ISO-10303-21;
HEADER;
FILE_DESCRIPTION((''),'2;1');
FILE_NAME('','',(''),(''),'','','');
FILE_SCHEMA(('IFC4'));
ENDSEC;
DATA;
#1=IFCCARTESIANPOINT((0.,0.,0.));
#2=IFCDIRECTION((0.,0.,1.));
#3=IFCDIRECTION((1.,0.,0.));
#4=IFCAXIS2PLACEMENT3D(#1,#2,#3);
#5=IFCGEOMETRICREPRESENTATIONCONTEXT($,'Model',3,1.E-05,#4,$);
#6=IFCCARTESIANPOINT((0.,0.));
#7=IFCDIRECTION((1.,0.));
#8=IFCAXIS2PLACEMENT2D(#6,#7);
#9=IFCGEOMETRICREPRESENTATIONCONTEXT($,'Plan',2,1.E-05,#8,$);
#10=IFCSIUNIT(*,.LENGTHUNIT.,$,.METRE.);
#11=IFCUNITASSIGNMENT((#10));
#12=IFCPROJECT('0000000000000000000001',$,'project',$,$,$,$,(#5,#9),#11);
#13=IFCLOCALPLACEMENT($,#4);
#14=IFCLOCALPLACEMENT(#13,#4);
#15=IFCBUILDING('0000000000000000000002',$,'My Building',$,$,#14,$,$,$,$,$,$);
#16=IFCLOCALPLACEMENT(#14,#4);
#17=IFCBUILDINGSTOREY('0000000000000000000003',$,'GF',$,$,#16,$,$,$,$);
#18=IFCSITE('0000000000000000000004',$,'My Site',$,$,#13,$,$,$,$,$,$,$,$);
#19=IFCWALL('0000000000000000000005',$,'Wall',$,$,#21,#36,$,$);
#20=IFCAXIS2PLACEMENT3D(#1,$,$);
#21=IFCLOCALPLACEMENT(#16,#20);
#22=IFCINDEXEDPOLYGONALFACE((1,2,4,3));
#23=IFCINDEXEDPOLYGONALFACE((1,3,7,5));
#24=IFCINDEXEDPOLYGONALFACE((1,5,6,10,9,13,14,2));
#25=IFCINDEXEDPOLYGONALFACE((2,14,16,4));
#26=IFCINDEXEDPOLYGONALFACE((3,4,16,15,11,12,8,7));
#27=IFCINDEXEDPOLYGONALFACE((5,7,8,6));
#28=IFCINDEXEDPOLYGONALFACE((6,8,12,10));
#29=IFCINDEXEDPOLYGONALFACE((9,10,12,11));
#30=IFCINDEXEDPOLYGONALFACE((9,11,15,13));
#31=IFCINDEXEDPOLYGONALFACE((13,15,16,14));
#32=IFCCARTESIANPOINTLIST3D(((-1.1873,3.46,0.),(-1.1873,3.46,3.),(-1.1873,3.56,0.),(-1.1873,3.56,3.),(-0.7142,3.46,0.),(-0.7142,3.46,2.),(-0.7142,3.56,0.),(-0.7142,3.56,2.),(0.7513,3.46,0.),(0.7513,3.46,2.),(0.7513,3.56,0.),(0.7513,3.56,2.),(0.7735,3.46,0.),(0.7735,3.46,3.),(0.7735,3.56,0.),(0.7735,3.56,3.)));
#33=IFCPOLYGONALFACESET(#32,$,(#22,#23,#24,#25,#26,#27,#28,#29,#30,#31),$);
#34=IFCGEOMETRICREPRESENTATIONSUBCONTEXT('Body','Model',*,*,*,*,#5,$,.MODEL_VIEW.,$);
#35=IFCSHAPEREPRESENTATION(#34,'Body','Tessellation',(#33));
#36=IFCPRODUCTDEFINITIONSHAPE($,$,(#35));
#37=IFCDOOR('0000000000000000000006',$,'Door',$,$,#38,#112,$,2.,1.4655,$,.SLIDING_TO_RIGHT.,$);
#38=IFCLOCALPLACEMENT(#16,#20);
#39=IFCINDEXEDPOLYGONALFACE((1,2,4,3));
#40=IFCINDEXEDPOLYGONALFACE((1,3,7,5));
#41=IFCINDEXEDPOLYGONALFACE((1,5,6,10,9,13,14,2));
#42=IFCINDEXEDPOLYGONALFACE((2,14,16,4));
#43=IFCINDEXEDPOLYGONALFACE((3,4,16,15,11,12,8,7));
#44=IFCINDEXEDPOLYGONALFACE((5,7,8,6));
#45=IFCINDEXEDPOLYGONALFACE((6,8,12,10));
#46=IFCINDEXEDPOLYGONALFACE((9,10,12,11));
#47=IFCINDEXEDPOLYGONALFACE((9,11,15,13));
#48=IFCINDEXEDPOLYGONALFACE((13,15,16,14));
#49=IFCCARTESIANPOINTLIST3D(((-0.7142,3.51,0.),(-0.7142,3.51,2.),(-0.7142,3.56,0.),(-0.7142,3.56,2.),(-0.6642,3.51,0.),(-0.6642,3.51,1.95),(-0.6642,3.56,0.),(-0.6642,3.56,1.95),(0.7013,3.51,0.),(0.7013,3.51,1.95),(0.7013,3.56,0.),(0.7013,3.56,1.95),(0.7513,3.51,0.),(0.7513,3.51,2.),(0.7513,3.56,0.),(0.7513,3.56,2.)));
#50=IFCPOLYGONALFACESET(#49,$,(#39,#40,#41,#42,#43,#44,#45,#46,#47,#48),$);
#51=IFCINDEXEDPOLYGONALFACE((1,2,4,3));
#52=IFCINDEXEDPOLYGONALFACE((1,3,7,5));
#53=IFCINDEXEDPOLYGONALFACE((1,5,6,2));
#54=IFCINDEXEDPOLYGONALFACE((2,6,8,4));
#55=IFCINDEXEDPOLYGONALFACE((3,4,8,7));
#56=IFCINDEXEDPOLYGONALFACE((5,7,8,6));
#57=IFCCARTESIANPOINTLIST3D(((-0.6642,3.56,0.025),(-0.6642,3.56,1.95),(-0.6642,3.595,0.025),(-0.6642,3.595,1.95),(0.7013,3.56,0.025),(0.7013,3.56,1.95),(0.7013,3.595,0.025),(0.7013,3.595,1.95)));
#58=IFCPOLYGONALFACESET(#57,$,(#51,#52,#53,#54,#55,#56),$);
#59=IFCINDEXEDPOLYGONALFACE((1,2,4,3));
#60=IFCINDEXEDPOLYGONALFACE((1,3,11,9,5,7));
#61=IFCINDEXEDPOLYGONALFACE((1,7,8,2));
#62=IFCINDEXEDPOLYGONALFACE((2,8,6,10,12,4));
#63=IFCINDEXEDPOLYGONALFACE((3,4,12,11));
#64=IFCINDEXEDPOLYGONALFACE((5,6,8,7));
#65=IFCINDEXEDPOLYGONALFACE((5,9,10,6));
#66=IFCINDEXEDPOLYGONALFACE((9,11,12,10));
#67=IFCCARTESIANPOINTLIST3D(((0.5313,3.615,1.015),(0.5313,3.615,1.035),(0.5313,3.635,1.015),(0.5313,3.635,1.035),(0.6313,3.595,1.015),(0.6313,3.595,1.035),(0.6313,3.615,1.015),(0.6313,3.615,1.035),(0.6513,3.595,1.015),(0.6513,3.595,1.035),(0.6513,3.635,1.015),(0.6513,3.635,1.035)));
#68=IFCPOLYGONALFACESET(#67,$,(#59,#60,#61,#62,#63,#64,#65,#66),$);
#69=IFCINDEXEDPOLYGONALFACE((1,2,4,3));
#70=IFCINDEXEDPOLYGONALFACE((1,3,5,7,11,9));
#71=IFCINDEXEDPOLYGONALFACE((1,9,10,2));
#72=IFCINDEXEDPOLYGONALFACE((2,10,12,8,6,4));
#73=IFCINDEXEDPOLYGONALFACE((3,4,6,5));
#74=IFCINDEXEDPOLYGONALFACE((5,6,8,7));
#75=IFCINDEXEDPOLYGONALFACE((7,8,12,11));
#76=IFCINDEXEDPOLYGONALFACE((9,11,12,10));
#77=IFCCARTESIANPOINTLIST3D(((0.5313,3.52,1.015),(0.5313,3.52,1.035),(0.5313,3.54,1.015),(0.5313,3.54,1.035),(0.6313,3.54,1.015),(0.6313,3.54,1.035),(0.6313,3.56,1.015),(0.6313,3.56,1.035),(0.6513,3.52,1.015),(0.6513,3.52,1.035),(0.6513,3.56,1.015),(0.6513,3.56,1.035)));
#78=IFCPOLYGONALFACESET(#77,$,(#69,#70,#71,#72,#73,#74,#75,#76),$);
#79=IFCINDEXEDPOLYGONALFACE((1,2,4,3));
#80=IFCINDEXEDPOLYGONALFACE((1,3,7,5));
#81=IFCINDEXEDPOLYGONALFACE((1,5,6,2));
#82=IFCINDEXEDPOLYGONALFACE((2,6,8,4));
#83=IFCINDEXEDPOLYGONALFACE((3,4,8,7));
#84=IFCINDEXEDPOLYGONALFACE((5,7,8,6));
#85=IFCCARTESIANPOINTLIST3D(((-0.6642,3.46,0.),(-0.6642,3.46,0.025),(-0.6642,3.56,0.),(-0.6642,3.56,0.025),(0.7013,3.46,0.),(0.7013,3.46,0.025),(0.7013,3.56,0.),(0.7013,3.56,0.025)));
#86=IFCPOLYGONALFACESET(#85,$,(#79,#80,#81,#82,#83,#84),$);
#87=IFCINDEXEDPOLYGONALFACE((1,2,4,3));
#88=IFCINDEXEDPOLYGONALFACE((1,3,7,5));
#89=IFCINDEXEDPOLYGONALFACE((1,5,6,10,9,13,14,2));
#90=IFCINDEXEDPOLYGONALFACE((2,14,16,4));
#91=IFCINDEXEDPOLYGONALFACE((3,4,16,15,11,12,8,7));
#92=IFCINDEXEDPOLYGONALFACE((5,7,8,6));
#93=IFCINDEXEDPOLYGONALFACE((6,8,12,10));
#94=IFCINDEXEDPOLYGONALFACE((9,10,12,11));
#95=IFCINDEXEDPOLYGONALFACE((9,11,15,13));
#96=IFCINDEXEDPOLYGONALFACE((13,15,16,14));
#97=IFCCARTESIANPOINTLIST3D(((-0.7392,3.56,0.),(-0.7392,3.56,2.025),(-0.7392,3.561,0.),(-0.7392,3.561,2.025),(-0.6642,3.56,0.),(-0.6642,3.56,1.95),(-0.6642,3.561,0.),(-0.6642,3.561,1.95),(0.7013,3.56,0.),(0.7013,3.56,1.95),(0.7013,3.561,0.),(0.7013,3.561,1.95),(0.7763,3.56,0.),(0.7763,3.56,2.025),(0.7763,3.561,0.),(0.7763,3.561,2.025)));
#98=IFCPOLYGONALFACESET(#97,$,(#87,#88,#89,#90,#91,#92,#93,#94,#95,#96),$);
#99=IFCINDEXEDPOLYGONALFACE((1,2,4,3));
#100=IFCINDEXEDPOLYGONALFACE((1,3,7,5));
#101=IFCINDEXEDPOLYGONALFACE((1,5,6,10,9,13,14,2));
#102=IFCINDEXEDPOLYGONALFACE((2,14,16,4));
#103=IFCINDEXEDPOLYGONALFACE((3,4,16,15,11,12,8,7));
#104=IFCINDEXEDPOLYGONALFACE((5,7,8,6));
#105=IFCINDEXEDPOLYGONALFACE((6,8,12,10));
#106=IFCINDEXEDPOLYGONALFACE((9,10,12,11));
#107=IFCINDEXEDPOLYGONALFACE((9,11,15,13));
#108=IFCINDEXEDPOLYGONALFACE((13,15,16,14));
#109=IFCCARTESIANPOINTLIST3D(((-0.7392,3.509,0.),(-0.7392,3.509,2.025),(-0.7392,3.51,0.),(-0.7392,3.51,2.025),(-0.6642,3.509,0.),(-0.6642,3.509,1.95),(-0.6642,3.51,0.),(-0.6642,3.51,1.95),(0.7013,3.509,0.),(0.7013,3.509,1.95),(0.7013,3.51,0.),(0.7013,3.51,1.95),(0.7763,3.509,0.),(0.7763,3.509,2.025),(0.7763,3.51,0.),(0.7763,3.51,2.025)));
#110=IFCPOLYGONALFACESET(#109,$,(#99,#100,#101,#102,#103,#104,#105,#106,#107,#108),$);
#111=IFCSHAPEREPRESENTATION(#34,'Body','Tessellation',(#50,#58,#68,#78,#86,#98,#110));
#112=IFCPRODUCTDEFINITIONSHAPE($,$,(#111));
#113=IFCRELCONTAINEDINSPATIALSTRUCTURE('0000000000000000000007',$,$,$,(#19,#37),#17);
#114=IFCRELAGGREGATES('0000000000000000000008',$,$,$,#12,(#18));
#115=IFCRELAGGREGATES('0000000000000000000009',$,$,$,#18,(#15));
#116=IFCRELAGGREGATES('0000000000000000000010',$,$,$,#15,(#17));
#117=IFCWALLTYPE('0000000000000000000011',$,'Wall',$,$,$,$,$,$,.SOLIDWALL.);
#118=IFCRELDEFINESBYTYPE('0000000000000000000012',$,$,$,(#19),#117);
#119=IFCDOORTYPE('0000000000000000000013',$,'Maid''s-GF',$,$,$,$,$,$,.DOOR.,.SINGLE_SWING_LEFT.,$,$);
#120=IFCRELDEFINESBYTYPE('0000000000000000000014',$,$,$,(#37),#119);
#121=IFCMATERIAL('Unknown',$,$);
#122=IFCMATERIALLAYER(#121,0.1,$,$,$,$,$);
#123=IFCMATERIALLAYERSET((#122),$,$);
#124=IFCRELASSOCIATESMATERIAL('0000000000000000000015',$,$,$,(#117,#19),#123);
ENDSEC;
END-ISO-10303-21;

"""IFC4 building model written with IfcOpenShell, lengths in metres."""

from ifc_helpers import new_model, entity, si_unit, frame, origin_with_axes, origin_2d_with_axis, place, context, subcontext, project, spatial, line, indexed_curve, outline, extrude, shape, source, transform, mapped, material, layer, layer_set, layer_usage, type_object, type_shapes, element, fill, save


model = new_model("IFC4")

# Units and contexts
model_context = context("Model", 3, precision=1e-05, world=origin_with_axes())
plan_context = context("Plan", 2, precision=1e-05, world=origin_2d_with_axis())
body_context_1 = subcontext(model_context, "Body", "Model", "MODEL_VIEW")
body_context_2 = subcontext(plan_context, "Body", "Plan", "PLAN_VIEW")
ifc_project = project(units=[si_unit("LENGTHUNIT", "METRE")], contexts=[model_context, plan_context])

# Site, building, storey
site_placement = place(None, origin_with_axes())
site = spatial("IfcSite", under=ifc_project, at=site_placement, Name="My Site")
building_placement = place(site_placement, origin_with_axes())
building = spatial("IfcBuilding", under=site, at=building_placement, Name="My Building")
storey_placement = place(building_placement, origin_with_axes())
storey = spatial("IfcBuildingStorey", under=building, at=storey_placement, Name="GF")

# Shared definitions
ifc_material_1 = material(Name="Unknown")

# Shared definitions
ifc_layer_1 = layer(ifc_material_1, 0.1)
ifc_layer_set_1 = layer_set([ifc_layer_1])
wall_type = type_object("IfcWallType", Name="Wall", PredefinedType="SOLIDWALL", material=ifc_layer_set_1)

# Wall, opening, door
ifc_layer_usage_1 = layer_usage(ifc_layer_set_1, "AXIS2", "POSITIVE", 0.0)
wall_1_placement = place(storey_placement, frame((0.7735, 3.56, 0.0), z_axis=(0.0, 0.0, 1.0), x_axis=(-1.0, 0.0, 0.0)))
wall_1 = element("IfcWall", 1, at=wall_1_placement, inside=storey, type_object=wall_type, material=ifc_layer_usage_1, Name="Wall", context=body_context_1, shape_type="SweptSolid", body=[
    extrude(outline(indexed_curve([(0.0, 0.0), (0.0, 0.1), (1.9608, 0.1), (1.9608, 0.0)], segments=[line(1, 2, 3, 4, 1)])), origin_with_axes(), (0.0, 0.0, 1.0), 3.0),
])
shared_shape_1 = source(origin_with_axes(), body_context_1, "Body", "SweptSolid", [
    extrude(outline(indexed_curve([(0.0, 0.0), (1.4655, 0.0), (1.4655, 2.0), (0.0, 2.0)], segments=[line(1, 2, 3, 4, 1)])), frame((0.0, -0.6, 0.0), z_axis=(0.0, -1.0, 0.0), x_axis=(1.0, 0.0, 0.0)), (0.0, 0.0, -1.0), 1.2),
])
opening_1_placement = place(wall_1_placement, frame((0.0222, 0.0, 0.0), z_axis=(0.0, 0.0, 1.0), x_axis=(1.0, 0.0, 0.0)))
opening_1 = element("IfcOpeningElement", 2, at=opening_1_placement, cuts=wall_1, PredefinedType="OPENING", context=body_context_1, shape_type="MappedRepresentation", body=[
    mapped(shared_shape_1, transform((0.0, 0.0, 0.0), x_axis=(1.0, 0.0, 0.0), y_axis=(0.0, 1.0, 0.0), z_axis=(0.0, 0.0, 1.0), scale=1.0)),
])
door_type = type_object("IfcDoorType", Name="Maid's-GF", OperationType="SINGLE_SWING_LEFT", PredefinedType="DOOR")
shared_shape_2 = source(origin_with_axes(), body_context_1, "Body", "SweptSolid", [
    extrude(outline(indexed_curve([(0.0, 0.0), (0.0, 2.0), (1.4655, 2.0), (1.4655, 0.0), (1.4155, 0.0), (1.4155, 1.95), (0.05, 1.95), (0.05, 0.0)], segments=[line(1, 2, 3, 4, 5, 6, 7, 8, 1)])), frame((0.0, 0.0, 0.0), z_axis=(0.0, -1.0, 0.0), x_axis=(1.0, 0.0, 0.0)), (0.0, 0.0, -1.0), 0.05),
    extrude(outline(indexed_curve([(0.0, 0.0), (1.3655, 0.0), (1.3655, 0.035), (0.0, 0.035)], segments=[line(1, 2, 3, 4, 1)])), frame((0.05, -0.035, 0.025), z_axis=(0.0, 0.0, 1.0), x_axis=(1.0, 0.0, 0.0)), (0.0, 0.0, 1.0), 1.925),
    extrude(outline(indexed_curve([(0.0, 0.0), (0.0, -0.04), (0.12, -0.04), (0.12, -0.02), (0.02, -0.02), (0.02, 0.0)], segments=[line(1, 2, 3, 4, 5, 6, 1)])), frame((0.1, -0.035, 1.015), z_axis=(0.0, 0.0, 1.0), x_axis=(1.0, 0.0, 0.0)), (0.0, 0.0, 1.0), 0.02),
    extrude(outline(indexed_curve([(0.0, 0.0), (0.0, 0.04), (0.12, 0.04), (0.12, 0.02), (0.02, 0.02), (0.02, 0.0)], segments=[line(1, 2, 3, 4, 5, 6, 1)])), frame((0.1, 0.0, 1.015), z_axis=(0.0, 0.0, 1.0), x_axis=(1.0, 0.0, 0.0)), (0.0, 0.0, 1.0), 0.02),
    extrude(outline(indexed_curve([(0.0, 0.0), (1.3655, 0.0), (1.3655, 0.1), (0.0, 0.1)], segments=[line(1, 2, 3, 4, 1)])), frame((0.05, 0.0, 0.0), z_axis=(0.0, 0.0, 1.0), x_axis=(1.0, 0.0, 0.0)), (0.0, 0.0, 1.0), 0.025),
    extrude(outline(indexed_curve([(0.0, 0.0), (0.0, 2.025), (1.5155, 2.025), (1.5155, 0.0), (1.4405, 0.0), (1.4405, 1.95), (0.075, 1.95), (0.075, 0.0)], segments=[line(1, 2, 3, 4, 5, 6, 7, 8, 1)])), frame((-0.025, -0.001, 0.0), z_axis=(0.0, -1.0, 0.0), x_axis=(1.0, 0.0, 0.0)), (0.0, 0.0, -1.0), 0.001),
    extrude(outline(indexed_curve([(0.0, 0.0), (0.0, 2.025), (1.5155, 2.025), (1.5155, 0.0), (1.4405, 0.0), (1.4405, 1.95), (0.075, 1.95), (0.075, 0.0)], segments=[line(1, 2, 3, 4, 5, 6, 7, 8, 1)])), frame((-0.025, 0.05, 0.0), z_axis=(0.0, -1.0, 0.0), x_axis=(1.0, 0.0, 0.0)), (0.0, 0.0, -1.0), 0.001),
])
shared_shape_3 = source(origin_with_axes(), body_context_2, "Body", "Curve2D", [
    entity("IfcIndexedPolyCurve", entity("IfcCartesianPointList2D", [[0.0, 0.0], [0.05, 0.0], [0.05, 0.05], [0.0, 0.05]]), [entity("IfcLineIndex", [1, 2, 3, 4, 1])]),
    entity("IfcIndexedPolyCurve", entity("IfcCartesianPointList2D", [[1.4655, 0.0], [1.4155, 0.0], [1.4155, 0.05], [1.4655, 0.05]]), [entity("IfcLineIndex", [1, 2, 3, 4, 1])]),
    entity("IfcIndexedPolyCurve", entity("IfcCartesianPointList2D", [[2.0983, -0.035], [0.7328, -0.035], [0.7328, 0.0], [2.0983, 0.0]]), [entity("IfcLineIndex", [1, 2, 3, 4, 1])]),
])
type_shapes(door_type, [shared_shape_2, shared_shape_3])
door_placement = place(opening_1_placement, frame((0.0, 0.0, 0.0), z_axis=(0.0, 0.0, 1.0), x_axis=(1.0, 0.0, 0.0)))
door = element("IfcDoor", 3, at=door_placement, inside=storey, type_object=door_type, Name="Door", OperationType="SLIDING_TO_RIGHT", OverallHeight=2.0, OverallWidth=1.4655, shapes=[
    shape(body_context_1, "Body", "MappedRepresentation", [mapped(shared_shape_2, transform((0.0, 0.0, 0.0), x_axis=(1.0, 0.0, 0.0), y_axis=(0.0, 1.0, 0.0), z_axis=(0.0, 0.0, 1.0), scale=1.0))]),
    shape(body_context_2, "Body", "MappedRepresentation", [mapped(shared_shape_3, transform((0.0, 0.0, 0.0), x_axis=(1.0, 0.0, 0.0), y_axis=(0.0, 1.0, 0.0), z_axis=(0.0, 0.0, 1.0), scale=1.0))]),
])
fill(opening_1, door)

save(model, "model.ifc")
